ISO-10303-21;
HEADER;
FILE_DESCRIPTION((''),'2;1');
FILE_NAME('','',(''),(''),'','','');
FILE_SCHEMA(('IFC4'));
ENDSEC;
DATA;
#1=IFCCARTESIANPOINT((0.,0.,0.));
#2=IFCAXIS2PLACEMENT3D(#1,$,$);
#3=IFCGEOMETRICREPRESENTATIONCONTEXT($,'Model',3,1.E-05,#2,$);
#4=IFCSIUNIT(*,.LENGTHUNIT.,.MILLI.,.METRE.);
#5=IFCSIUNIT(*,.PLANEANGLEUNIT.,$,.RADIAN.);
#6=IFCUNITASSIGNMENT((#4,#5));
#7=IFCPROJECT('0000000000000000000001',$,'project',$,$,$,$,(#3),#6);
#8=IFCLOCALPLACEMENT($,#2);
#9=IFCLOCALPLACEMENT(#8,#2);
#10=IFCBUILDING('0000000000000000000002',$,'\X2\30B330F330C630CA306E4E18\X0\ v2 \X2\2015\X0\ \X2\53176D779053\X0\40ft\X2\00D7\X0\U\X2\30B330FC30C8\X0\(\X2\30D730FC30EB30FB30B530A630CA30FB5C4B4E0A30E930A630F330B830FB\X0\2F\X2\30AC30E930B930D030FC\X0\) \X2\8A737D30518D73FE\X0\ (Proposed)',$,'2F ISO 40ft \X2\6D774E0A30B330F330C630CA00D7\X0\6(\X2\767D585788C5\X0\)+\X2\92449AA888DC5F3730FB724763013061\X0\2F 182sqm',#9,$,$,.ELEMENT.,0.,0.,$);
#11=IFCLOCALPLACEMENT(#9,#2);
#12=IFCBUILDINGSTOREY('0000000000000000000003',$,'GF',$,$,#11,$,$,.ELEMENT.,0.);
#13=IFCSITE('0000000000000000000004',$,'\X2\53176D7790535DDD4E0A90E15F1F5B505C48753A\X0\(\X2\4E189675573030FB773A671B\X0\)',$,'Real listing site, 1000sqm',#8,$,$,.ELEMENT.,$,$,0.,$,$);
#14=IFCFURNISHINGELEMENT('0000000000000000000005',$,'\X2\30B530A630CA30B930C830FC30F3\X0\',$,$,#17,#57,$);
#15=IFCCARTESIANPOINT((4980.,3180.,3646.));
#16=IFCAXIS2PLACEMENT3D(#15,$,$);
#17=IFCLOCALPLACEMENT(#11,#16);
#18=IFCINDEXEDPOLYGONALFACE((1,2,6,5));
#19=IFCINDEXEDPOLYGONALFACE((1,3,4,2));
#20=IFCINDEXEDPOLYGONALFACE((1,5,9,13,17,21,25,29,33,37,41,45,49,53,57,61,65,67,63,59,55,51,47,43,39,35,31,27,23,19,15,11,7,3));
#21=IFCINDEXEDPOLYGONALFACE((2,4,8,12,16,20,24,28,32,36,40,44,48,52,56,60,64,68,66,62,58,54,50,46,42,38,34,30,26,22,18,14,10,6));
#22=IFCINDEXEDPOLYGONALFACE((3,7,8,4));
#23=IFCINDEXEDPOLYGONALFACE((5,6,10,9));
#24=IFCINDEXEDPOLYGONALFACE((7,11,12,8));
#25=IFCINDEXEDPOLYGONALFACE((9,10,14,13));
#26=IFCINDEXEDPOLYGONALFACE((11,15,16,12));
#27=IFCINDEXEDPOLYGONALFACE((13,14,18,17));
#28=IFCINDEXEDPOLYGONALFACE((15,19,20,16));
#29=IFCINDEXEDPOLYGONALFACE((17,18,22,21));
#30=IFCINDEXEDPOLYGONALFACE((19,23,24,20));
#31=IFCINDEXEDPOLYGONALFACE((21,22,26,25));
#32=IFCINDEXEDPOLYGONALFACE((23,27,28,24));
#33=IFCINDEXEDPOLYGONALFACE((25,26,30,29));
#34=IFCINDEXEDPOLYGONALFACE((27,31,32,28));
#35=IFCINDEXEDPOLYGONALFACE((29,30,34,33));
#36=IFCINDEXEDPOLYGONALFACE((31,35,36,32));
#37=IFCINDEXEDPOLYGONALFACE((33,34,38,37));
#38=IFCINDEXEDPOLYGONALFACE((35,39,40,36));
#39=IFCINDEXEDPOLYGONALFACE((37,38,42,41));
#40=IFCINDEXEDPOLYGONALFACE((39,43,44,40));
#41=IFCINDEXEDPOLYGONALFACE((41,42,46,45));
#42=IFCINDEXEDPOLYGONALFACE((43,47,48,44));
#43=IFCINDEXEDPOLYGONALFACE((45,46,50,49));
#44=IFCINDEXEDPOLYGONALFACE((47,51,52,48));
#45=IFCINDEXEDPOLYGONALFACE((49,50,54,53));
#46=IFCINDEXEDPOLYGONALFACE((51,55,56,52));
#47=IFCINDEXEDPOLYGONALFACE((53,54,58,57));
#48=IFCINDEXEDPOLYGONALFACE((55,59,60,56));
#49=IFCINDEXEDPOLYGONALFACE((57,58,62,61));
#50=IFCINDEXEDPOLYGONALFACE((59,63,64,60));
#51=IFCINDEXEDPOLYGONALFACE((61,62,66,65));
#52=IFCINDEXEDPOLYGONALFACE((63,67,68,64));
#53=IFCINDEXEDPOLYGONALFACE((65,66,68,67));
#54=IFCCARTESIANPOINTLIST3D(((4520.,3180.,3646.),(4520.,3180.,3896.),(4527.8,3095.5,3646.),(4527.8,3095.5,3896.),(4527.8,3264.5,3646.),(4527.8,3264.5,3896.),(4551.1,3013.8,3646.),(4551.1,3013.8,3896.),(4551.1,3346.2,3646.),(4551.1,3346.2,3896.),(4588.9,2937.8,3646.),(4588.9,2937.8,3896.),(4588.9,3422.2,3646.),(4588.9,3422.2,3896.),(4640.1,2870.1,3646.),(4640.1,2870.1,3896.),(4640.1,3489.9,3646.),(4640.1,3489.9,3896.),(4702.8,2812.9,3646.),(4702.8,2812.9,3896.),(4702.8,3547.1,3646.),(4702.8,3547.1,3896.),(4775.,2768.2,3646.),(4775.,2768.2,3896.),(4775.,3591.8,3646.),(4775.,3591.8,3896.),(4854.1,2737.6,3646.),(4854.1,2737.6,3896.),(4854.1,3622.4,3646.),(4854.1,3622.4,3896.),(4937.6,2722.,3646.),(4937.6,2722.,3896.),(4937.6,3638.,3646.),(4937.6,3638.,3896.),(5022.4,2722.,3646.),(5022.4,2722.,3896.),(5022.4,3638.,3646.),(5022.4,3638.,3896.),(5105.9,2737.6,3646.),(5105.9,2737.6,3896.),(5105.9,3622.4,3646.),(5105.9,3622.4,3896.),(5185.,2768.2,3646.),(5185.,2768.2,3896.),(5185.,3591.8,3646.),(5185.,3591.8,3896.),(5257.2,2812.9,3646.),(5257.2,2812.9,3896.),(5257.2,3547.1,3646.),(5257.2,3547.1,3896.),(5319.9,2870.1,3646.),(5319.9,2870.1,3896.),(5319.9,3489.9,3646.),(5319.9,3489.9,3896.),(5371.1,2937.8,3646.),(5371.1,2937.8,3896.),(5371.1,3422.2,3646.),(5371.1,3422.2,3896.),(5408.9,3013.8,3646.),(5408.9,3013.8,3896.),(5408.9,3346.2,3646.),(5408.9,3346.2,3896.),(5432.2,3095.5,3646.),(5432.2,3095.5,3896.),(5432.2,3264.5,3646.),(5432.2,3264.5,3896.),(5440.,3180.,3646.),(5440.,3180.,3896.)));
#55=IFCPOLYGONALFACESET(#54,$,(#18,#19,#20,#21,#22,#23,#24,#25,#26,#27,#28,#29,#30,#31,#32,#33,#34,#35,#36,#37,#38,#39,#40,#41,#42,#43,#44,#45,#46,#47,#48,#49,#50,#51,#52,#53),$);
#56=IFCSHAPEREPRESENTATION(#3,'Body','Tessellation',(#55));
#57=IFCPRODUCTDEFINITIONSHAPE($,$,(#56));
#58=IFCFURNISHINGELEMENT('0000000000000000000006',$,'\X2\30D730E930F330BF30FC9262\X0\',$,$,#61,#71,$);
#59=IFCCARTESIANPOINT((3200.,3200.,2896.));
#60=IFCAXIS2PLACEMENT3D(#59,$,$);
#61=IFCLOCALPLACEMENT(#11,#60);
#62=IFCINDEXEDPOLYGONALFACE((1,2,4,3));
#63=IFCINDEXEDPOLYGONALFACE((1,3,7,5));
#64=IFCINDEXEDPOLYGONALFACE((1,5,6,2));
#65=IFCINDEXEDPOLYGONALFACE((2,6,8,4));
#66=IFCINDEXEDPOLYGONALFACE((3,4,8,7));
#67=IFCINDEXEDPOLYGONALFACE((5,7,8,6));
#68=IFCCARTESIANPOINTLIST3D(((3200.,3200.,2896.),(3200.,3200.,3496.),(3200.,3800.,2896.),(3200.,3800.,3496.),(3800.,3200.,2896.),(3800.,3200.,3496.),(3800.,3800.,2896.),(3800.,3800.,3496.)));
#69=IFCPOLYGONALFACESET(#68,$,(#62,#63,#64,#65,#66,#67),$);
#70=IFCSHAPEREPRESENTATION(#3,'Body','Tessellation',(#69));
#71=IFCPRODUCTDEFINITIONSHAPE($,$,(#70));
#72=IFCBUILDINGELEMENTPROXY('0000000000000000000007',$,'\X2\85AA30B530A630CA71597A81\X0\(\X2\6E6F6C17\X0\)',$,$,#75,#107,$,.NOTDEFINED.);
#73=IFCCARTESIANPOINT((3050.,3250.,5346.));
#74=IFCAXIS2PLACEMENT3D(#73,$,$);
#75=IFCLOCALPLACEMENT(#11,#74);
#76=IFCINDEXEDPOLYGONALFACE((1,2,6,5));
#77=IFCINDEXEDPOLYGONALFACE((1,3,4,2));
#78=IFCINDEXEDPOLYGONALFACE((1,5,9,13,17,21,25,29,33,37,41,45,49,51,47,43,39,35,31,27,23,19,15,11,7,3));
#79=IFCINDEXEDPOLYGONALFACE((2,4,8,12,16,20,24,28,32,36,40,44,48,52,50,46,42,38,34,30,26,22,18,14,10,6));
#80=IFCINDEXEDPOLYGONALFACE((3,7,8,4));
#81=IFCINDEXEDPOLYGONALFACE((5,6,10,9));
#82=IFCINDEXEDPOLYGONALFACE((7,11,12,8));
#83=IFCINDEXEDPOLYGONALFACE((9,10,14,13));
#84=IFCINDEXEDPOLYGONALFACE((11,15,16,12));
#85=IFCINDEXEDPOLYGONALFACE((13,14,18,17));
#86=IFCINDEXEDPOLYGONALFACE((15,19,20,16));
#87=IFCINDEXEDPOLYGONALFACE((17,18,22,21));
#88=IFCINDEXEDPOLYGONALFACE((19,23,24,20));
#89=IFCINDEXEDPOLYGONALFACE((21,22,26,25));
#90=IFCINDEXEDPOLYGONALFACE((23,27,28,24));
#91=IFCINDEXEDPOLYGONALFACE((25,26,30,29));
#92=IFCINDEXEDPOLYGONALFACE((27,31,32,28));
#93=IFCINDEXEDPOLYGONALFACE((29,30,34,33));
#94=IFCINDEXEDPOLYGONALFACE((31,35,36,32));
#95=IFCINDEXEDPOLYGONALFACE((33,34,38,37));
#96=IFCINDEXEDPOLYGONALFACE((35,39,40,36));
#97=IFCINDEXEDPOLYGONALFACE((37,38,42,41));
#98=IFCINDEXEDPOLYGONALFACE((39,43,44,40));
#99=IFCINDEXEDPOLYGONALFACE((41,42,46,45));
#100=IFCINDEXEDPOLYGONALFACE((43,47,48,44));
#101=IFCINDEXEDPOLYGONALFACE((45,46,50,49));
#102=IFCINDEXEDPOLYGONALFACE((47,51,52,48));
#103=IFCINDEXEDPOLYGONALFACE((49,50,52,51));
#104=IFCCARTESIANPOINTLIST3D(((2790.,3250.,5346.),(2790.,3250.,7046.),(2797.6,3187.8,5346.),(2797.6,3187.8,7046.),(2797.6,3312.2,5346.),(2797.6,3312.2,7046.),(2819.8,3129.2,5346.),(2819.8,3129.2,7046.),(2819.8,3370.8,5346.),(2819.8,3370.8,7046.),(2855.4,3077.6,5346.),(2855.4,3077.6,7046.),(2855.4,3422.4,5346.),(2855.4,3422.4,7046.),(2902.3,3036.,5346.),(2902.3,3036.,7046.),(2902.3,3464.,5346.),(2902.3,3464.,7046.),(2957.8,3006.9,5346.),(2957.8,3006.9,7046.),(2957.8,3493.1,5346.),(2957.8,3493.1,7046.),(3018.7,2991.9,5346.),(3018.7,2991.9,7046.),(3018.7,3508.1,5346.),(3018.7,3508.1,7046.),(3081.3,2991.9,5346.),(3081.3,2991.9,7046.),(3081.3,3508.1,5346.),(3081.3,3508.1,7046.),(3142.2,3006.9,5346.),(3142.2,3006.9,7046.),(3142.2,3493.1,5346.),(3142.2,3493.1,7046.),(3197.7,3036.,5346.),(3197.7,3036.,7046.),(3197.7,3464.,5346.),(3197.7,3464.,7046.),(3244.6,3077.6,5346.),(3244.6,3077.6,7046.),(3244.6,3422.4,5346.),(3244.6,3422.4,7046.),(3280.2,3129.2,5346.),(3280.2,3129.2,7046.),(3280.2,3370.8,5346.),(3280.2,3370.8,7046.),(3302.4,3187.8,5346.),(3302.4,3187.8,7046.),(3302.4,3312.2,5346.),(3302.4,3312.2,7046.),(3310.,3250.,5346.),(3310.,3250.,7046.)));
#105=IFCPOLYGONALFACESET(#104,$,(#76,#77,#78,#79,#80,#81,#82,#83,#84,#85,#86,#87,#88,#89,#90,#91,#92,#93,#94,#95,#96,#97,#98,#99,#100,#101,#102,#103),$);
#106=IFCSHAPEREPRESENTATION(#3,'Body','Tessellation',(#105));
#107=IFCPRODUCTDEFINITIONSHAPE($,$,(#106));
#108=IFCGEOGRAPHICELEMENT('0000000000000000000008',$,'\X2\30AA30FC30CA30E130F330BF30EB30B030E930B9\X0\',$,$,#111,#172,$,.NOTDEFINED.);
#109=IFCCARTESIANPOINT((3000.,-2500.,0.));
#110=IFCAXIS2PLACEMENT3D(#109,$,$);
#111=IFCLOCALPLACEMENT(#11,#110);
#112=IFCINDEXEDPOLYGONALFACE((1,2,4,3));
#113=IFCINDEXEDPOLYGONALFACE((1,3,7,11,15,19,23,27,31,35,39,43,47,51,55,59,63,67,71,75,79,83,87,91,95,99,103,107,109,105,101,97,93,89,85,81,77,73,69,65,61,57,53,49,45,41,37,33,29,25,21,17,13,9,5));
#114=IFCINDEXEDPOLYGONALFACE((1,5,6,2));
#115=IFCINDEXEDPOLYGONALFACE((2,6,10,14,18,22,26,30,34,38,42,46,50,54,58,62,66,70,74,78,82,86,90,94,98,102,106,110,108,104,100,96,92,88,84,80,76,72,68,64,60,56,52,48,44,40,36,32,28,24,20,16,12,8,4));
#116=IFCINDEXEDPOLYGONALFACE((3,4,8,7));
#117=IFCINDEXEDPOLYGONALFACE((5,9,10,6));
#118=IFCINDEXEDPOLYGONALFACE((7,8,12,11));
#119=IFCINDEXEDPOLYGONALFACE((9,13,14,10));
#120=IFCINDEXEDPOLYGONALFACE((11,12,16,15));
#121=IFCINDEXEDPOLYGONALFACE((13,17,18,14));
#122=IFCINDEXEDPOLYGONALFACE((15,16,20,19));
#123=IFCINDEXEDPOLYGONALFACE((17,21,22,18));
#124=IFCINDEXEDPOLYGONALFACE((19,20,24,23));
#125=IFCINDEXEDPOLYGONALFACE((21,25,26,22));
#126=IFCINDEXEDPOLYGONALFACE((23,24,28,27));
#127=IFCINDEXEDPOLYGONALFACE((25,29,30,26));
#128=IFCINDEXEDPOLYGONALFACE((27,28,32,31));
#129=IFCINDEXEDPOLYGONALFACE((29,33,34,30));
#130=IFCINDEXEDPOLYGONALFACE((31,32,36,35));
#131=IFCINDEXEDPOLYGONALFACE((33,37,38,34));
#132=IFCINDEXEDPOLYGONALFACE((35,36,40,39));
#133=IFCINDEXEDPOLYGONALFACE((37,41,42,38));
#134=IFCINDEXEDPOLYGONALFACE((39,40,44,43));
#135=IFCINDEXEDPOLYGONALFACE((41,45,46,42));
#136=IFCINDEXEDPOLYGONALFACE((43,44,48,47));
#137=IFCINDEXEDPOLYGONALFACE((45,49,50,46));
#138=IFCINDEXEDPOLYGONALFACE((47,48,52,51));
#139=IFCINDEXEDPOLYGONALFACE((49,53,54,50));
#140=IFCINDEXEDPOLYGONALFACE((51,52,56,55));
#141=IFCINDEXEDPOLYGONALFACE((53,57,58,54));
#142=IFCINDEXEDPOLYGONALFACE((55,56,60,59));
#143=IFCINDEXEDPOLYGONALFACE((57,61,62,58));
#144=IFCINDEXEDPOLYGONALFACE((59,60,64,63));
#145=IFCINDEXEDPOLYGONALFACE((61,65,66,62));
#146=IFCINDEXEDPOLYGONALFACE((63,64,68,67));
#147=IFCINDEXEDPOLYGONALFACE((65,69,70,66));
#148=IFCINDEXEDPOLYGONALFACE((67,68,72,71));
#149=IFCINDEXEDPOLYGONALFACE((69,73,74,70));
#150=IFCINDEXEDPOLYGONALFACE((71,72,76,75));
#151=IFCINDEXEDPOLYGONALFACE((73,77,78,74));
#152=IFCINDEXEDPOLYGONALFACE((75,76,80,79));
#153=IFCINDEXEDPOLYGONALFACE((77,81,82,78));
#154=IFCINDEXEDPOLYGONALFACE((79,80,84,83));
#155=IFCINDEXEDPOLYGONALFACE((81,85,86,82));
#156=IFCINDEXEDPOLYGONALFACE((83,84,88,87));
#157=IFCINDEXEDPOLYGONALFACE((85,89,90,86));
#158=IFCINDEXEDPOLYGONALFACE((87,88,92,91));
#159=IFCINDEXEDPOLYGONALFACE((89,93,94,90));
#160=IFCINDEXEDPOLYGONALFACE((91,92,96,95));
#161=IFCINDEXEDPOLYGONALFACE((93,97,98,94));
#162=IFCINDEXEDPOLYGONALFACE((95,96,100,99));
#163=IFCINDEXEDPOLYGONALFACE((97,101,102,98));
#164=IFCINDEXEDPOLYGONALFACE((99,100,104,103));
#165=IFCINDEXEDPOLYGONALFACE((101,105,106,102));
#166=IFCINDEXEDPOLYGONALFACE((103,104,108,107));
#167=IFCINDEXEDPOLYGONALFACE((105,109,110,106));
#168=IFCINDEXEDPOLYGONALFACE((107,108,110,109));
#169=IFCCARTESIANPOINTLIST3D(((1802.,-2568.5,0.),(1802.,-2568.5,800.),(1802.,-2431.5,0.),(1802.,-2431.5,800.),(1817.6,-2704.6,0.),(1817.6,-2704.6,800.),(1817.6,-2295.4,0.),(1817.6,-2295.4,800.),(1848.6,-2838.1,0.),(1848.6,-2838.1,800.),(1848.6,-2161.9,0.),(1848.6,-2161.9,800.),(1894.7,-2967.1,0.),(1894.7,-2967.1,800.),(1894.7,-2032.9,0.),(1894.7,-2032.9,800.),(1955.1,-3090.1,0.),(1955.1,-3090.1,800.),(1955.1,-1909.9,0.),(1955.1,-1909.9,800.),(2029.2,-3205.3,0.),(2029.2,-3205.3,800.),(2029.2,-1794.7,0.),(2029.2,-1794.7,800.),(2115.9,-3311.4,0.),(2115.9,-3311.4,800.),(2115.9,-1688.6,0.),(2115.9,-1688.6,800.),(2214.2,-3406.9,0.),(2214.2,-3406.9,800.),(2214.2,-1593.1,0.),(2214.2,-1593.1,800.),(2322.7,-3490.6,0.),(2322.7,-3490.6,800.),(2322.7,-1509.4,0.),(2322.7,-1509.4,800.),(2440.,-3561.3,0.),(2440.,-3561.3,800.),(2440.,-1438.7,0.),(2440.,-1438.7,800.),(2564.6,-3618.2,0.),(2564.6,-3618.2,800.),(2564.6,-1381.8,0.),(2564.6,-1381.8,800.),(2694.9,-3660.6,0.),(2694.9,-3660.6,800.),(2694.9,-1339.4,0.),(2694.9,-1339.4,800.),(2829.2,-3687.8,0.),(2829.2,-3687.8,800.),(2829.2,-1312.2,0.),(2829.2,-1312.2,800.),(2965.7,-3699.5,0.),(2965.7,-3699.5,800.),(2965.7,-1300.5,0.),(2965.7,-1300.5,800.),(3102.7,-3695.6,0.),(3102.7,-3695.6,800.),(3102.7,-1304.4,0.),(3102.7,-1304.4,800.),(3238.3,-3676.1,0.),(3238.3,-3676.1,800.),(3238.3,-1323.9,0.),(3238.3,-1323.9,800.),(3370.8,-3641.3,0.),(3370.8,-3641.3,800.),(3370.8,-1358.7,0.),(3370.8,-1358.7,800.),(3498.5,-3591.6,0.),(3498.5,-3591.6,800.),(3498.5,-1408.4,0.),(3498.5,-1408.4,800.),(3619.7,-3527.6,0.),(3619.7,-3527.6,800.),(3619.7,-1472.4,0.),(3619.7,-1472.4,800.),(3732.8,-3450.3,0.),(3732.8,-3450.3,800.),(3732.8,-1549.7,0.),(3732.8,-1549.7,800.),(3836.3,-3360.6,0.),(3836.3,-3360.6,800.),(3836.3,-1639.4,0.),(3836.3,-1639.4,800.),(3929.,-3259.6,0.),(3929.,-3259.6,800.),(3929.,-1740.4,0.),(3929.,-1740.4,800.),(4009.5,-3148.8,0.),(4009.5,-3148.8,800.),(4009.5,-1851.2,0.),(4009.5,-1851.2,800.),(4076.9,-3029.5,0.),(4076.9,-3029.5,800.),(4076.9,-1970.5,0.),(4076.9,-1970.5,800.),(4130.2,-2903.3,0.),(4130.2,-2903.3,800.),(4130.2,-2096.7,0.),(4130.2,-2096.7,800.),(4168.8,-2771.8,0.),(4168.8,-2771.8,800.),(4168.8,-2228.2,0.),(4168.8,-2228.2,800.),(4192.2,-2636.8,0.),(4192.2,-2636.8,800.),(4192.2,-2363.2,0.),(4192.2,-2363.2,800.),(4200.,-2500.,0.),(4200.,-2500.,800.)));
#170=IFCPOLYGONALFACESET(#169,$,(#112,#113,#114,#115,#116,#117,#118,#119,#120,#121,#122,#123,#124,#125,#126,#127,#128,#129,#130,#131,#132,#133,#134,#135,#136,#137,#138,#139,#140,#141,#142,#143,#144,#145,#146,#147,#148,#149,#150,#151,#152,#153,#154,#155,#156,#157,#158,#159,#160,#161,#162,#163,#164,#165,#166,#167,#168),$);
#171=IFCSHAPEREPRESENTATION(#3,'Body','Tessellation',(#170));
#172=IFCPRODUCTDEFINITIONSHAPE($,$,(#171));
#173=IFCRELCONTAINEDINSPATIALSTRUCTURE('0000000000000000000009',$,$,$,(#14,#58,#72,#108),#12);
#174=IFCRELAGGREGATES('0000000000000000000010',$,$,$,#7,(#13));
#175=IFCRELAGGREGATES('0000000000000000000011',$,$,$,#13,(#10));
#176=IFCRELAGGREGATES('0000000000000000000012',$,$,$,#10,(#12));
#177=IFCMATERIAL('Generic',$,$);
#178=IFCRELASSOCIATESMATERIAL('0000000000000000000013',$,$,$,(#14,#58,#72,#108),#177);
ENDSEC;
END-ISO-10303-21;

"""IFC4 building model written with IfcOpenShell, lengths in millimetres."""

from ifc_helpers import new_model, si_unit, frame, frame_2d, origin, origin_2d, place, context, project, spatial, rectangle, circle, extrude, material, element, save


model = new_model("IFC4")

# Units and contexts
model_context = context("Model", 3, precision=1e-05, world=origin())
ifc_project = project(units=[si_unit("LENGTHUNIT", "METRE", prefix="MILLI"), si_unit("PLANEANGLEUNIT", "RADIAN")], contexts=[model_context])

# Site, building, storey
site_placement = place(None, origin())
site = spatial("IfcSite", under=ifc_project, at=site_placement, Name="北海道川上郡弟子屈町(丘陵地・眺望)", ObjectType="Real listing site, 1000sqm", CompositionType="ELEMENT", RefElevation=0.0)
building_placement = place(site_placement, origin())
building = spatial("IfcBuilding", under=site, at=building_placement, Name="コンテナの丘 v2 ― 北海道40ft×Uコート(プール・サウナ・屋上ラウンジ・2Fガラスバー) 詳細再現 (Proposed)", ObjectType="2F ISO 40ft 海上コンテナ×6(白塗装)+鉄骨補強・片持ち2F 182sqm", CompositionType="ELEMENT", ElevationOfRefHeight=0.0, ElevationOfTerrain=0.0)
storey_placement = place(building_placement, origin())
storey = spatial("IfcBuildingStorey", under=building, at=storey_placement, Name="GF", CompositionType="ELEMENT", Elevation=0.0)

# Shared definitions
ifc_material = material(Name="Generic")

# Furnishing elements
furnishing_1_placement = place(storey_placement, frame((4980.0, 3180.0, 3646.0)))
element("IfcFurnishingElement", 1, at=furnishing_1_placement, inside=storey, material=ifc_material, Name="サウナストーン", context=model_context, shape_type="SweptSolid", body=[
    extrude(circle(Radius=460.0, at=origin_2d()), frame((4980.0, 3180.0, 3646.0)), (0.0, 0.0, 1.0), 250.0),
])
furnishing_2_placement = place(storey_placement, frame((3200.0, 3200.0, 2896.0)))
element("IfcFurnishingElement", 2, at=furnishing_2_placement, inside=storey, material=ifc_material, Name="プランター鉢", context=model_context, shape_type="SweptSolid", body=[
    extrude(rectangle(XDim=600.0, YDim=600.0, at=frame_2d((300.0, 300.0))), frame((3200.0, 3200.0, 2896.0)), (0.0, 0.0, 1.0), 600.0),
])

# Building element proxy
proxy_1_placement = place(storey_placement, frame((3050.0, 3250.0, 5346.0)))
element("IfcBuildingElementProxy", 3, at=proxy_1_placement, inside=storey, material=ifc_material, Name="薪サウナ煙突(湯気)", PredefinedType="NOTDEFINED", context=model_context, shape_type="SweptSolid", body=[
    extrude(circle(Radius=260.0, at=origin_2d()), frame((3050.0, 3250.0, 5346.0)), (0.0, 0.0, 1.0), 1700.0),
])

# Geographic element
geographic_element_1_placement = place(storey_placement, frame((3000.0, -2500.0, 0.0)))
element("IfcGeographicElement", 4, at=geographic_element_1_placement, inside=storey, material=ifc_material, Name="オーナメンタルグラス", PredefinedType="NOTDEFINED", context=model_context, shape_type="SweptSolid", body=[
    extrude(circle(Radius=1200.0, at=origin_2d()), frame((3000.0, -2500.0, 0.0)), (0.0, 0.0, 1.0), 800.0),
])

save(model, "model.ifc")
